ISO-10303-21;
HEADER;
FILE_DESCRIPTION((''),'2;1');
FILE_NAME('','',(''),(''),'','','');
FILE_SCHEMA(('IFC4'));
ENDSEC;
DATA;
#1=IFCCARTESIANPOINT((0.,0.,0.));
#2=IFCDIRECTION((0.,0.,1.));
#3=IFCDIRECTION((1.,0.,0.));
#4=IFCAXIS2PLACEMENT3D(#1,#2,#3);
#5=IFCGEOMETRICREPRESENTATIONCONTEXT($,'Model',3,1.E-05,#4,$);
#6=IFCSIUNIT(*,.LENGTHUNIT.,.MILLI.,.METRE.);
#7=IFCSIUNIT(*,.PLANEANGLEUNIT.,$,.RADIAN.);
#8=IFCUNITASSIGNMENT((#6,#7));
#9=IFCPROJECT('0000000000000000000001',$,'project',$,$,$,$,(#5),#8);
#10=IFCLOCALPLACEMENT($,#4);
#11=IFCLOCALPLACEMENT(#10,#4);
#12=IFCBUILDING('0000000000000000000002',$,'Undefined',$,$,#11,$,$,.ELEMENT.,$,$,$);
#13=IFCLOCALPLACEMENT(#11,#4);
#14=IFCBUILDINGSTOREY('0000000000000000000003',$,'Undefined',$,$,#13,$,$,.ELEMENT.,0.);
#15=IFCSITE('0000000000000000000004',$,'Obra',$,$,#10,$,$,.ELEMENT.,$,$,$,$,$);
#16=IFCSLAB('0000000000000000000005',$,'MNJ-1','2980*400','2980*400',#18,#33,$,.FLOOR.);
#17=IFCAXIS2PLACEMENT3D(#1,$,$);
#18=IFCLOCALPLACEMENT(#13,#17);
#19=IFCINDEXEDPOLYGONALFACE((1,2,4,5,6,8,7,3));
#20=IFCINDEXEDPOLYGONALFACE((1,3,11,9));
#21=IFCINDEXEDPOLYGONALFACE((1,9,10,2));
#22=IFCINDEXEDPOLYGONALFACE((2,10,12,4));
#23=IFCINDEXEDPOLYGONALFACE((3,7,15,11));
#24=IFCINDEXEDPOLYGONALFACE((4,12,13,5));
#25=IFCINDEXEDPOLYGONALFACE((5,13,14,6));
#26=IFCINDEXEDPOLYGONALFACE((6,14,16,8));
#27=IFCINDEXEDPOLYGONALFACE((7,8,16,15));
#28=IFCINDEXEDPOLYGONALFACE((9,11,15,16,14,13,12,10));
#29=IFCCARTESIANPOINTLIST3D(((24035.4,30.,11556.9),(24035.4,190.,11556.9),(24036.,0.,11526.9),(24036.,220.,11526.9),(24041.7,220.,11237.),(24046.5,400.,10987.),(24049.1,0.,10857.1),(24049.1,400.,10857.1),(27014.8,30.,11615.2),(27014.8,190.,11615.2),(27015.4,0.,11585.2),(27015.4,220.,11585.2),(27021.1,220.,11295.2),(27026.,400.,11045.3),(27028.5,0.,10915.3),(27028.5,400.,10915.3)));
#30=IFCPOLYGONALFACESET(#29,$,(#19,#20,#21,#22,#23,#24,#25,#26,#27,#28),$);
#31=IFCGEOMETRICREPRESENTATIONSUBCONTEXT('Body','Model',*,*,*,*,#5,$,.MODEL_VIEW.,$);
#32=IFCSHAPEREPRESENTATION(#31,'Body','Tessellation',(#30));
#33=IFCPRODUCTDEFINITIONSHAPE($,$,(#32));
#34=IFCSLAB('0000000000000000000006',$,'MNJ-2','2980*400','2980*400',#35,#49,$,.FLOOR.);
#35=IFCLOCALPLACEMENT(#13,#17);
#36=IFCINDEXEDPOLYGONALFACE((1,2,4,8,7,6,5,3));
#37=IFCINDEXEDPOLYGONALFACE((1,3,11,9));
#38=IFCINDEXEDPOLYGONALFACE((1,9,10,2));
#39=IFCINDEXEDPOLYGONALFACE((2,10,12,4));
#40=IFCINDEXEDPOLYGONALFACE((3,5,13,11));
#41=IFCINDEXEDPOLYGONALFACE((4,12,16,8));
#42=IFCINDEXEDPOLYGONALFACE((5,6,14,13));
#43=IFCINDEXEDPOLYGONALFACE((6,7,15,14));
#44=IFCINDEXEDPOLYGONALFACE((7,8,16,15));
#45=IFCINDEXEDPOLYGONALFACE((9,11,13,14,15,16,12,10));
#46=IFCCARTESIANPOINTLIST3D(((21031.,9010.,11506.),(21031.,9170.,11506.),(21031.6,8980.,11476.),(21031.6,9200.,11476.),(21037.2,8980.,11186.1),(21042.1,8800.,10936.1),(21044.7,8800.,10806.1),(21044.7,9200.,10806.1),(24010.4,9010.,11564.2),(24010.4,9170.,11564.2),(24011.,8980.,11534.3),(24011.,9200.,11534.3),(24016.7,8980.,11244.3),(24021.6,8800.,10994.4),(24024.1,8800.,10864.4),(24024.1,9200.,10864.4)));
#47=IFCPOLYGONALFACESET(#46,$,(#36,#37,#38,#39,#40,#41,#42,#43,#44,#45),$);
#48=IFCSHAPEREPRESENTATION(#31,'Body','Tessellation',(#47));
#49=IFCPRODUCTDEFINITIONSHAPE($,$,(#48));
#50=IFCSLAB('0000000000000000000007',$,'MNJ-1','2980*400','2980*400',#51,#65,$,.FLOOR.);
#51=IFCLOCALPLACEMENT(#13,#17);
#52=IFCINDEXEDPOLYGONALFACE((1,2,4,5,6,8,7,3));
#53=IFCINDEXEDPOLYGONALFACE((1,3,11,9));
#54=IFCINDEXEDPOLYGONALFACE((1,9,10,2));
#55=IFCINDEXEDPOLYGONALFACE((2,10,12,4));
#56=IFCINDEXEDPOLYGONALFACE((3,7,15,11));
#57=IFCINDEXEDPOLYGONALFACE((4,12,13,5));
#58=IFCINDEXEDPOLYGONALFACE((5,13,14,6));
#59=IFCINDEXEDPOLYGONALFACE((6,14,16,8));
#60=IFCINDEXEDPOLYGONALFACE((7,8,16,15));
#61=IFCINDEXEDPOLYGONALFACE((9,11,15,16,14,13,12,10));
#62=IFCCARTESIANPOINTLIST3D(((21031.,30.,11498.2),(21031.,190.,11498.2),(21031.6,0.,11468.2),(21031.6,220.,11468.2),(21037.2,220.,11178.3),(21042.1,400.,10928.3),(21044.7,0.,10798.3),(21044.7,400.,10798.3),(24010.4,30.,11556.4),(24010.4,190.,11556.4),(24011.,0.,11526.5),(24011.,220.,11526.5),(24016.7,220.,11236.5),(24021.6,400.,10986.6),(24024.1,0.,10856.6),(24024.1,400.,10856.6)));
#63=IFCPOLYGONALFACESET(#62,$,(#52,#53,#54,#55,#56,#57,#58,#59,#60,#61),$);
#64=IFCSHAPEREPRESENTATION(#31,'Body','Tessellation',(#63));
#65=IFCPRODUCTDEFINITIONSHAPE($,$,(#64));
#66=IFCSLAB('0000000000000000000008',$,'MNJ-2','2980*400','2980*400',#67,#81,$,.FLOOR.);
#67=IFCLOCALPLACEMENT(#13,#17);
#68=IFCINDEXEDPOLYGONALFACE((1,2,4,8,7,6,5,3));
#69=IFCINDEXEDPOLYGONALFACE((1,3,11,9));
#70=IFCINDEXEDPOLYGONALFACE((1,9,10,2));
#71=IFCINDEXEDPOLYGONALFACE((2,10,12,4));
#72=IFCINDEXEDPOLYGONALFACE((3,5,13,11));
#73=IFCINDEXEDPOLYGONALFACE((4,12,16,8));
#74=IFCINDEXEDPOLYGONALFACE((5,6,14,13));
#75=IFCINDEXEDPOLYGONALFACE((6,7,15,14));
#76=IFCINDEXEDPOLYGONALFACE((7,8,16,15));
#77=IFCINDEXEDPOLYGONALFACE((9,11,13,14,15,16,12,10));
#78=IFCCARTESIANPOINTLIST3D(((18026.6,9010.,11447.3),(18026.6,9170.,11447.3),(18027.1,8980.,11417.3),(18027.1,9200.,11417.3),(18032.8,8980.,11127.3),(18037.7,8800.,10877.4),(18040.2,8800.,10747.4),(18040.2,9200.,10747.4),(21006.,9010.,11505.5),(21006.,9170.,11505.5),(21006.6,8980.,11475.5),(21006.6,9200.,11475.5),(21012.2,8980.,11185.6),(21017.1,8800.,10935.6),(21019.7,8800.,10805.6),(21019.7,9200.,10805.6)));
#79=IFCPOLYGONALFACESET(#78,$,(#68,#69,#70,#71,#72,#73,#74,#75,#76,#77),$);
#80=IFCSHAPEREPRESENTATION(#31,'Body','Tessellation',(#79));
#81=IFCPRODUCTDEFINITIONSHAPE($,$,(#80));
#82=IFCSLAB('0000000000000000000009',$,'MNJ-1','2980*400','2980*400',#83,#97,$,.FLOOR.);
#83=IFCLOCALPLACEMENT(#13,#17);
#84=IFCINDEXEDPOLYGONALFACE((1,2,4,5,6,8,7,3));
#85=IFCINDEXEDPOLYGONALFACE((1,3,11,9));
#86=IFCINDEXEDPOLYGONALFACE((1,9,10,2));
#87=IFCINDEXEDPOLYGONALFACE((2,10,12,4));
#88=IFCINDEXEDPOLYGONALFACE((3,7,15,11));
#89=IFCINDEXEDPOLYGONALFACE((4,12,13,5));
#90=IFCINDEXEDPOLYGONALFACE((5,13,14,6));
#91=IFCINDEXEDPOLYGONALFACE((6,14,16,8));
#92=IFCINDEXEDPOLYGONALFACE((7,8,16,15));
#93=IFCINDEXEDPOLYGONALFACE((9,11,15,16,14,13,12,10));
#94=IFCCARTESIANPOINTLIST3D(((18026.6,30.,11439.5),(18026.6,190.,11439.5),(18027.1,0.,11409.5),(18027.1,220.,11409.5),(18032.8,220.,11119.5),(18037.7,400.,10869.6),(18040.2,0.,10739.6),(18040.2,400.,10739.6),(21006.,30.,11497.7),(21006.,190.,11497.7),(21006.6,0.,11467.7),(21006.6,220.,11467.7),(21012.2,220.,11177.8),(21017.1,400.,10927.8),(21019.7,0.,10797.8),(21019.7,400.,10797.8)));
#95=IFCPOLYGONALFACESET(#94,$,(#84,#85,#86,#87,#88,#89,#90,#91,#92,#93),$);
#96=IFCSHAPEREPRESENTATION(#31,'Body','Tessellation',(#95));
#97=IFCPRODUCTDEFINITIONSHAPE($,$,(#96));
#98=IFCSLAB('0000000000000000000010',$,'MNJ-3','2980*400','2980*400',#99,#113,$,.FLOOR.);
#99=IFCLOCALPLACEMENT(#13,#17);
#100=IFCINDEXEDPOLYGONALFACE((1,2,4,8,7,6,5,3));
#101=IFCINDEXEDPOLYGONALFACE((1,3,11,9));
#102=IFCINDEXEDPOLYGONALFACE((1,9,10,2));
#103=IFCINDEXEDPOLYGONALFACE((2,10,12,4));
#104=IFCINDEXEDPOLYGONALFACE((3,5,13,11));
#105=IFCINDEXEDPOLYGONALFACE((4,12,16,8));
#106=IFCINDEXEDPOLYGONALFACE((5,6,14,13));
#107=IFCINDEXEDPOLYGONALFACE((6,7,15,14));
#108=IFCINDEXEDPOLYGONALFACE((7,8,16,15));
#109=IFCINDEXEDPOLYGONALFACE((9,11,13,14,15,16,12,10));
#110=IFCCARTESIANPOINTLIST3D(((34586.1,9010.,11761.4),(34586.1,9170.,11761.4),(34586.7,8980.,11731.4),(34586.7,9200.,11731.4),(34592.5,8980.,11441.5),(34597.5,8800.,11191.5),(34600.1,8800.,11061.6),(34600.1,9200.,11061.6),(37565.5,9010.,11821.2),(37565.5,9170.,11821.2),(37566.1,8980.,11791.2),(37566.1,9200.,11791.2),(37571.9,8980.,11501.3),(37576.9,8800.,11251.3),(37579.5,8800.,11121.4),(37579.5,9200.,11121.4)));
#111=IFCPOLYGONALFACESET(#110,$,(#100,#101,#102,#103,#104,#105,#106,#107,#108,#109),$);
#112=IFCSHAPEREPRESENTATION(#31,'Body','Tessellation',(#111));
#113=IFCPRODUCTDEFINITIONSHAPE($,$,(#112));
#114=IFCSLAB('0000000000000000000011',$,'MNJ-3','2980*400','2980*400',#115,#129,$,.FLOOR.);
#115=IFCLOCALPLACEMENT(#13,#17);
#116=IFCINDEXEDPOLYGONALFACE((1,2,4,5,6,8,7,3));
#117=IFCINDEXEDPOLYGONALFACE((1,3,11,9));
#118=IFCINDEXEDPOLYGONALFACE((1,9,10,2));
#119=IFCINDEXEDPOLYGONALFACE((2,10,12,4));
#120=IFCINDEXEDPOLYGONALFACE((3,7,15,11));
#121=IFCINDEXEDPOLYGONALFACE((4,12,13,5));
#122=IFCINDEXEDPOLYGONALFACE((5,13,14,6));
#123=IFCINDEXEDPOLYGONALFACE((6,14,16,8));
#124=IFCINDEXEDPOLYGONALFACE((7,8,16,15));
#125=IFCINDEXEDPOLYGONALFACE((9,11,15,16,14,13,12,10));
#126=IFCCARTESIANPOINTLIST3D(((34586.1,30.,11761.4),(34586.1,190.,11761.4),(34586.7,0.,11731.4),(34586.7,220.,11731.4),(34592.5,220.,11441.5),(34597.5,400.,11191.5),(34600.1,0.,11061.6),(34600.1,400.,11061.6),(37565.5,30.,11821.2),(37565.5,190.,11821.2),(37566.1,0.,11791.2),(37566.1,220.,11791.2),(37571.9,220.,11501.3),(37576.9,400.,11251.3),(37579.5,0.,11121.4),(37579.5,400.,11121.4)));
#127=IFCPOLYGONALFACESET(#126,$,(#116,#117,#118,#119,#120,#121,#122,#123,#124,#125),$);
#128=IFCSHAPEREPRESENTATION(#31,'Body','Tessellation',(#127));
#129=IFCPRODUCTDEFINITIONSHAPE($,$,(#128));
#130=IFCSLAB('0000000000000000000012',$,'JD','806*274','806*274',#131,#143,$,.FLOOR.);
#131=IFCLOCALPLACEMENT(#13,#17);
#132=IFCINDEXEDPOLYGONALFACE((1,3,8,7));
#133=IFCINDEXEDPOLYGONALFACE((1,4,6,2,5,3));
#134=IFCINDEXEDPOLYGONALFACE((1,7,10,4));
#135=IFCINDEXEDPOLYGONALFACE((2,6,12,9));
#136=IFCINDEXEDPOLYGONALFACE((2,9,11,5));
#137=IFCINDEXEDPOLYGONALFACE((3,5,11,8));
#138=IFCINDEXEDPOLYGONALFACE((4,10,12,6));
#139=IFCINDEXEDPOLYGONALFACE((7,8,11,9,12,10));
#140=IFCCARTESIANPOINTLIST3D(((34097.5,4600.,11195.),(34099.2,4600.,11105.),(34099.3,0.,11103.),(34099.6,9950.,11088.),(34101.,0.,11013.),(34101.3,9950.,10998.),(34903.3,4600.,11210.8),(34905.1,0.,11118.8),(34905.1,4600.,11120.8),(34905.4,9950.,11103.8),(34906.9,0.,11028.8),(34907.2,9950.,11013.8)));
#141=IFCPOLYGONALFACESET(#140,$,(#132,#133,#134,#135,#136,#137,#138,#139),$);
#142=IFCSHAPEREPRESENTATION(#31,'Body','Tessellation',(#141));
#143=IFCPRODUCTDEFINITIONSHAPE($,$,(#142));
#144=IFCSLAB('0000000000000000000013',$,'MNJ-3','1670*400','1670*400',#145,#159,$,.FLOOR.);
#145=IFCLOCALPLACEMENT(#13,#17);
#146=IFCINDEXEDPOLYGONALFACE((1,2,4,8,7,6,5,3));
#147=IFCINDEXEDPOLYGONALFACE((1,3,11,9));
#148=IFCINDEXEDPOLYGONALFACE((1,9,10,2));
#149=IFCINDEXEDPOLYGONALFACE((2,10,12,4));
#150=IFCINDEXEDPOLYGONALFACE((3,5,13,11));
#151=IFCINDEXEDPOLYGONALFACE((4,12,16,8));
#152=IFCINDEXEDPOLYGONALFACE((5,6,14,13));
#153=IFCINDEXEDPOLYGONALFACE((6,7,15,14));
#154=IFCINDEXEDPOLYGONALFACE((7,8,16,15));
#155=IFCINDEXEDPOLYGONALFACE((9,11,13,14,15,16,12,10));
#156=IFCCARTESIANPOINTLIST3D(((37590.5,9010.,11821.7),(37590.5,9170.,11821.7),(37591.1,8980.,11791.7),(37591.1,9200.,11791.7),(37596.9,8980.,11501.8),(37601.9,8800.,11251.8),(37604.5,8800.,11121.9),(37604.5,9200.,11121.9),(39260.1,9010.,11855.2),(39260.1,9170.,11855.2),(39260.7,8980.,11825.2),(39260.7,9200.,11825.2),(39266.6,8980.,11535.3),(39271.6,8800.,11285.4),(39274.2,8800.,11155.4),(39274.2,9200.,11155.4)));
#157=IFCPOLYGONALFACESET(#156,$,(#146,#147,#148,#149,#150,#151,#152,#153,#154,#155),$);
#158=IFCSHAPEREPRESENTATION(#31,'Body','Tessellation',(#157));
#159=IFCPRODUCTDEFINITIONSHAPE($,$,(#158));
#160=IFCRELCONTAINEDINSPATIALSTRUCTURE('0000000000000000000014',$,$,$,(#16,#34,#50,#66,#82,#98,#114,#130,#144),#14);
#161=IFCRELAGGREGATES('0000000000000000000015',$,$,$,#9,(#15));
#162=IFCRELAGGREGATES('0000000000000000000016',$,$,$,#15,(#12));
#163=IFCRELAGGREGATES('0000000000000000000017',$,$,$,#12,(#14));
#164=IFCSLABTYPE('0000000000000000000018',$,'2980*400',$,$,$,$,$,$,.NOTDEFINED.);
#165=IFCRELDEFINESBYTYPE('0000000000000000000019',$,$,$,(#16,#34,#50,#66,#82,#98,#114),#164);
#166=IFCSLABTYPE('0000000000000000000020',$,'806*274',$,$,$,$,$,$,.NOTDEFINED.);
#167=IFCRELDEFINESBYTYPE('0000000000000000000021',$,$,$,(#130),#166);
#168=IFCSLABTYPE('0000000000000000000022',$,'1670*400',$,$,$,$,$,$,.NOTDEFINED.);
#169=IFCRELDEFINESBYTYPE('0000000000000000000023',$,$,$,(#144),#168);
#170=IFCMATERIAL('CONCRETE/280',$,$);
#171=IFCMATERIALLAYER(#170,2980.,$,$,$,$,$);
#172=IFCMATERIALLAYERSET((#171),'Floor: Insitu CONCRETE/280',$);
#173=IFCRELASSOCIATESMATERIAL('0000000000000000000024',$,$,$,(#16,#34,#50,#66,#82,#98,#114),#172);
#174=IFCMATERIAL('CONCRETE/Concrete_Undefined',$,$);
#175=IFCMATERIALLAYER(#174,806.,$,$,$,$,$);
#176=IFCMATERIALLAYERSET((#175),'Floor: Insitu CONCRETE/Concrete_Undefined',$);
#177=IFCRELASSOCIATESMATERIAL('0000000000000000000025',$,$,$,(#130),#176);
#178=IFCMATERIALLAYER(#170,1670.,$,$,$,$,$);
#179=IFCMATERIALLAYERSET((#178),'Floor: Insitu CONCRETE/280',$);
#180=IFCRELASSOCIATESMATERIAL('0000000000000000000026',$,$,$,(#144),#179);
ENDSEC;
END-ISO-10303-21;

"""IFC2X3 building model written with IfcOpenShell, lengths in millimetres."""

from ifc_helpers import new_model, si_unit, frame, origin_with_axes, place, context, subcontext, project, spatial, polyline, outline, extrude, material, layer, layer_set, layer_usage, type_object, element, save


model = new_model("IFC2X3")

# Units and contexts
model_context = context("Model", 3, precision=1e-05, world=origin_with_axes())
body_context = subcontext(model_context, "Body", "Model", "MODEL_VIEW")
ifc_project = project(units=[si_unit("LENGTHUNIT", "METRE", prefix="MILLI"), si_unit("PLANEANGLEUNIT", "RADIAN")], contexts=[model_context])

# Site, building, storey
site_placement = place(None, origin_with_axes())
site = spatial("IfcSite", under=ifc_project, at=site_placement, Name="Obra", CompositionType="ELEMENT")
building_placement = place(site_placement, origin_with_axes())
building = spatial("IfcBuilding", under=site, at=building_placement, Name="Undefined", CompositionType="ELEMENT")
storey_placement = place(building_placement, origin_with_axes())
storey = spatial("IfcBuildingStorey", under=building, at=storey_placement, Name="Undefined", CompositionType="ELEMENT", Elevation=0.0)

# Shared definitions
ifc_material_1 = material(Name="CONCRETE/280")

# Slabs
ifc_layer_1 = layer(ifc_material_1, 2980.0)
ifc_layer_set_1 = layer_set([ifc_layer_1], Name="Floor: Insitu CONCRETE/280")
slab_type_1 = type_object("IfcSlabType", Name="2980*400", PredefinedType="NOTDEFINED")
ifc_layer_usage_1 = layer_usage(ifc_layer_set_1, "AXIS3", "POSITIVE", -1490.0)
slab_1_placement = place(storey_placement, frame((25525.7, 0.0, 11556.1), z_axis=(0.999809, 0.0, 0.019547), x_axis=(0.019547, 0.0, -0.999809)))
element("IfcSlab", 1, at=slab_1_placement, inside=storey, type_object=slab_type_1, material=ifc_layer_usage_1, Name="MNJ-1", Description="2980*400", ObjectType="2980*400", PredefinedType="FLOOR", context=body_context, shape_type="SweptSolid", body=[
    extrude(outline(polyline([(0.0, 0.0), (670.0, 0.0), (670.0, 400.0), (540.0, 400.0), (290.0, 220.0), (0.0, 220.0), (-30.0, 190.0), (-30.0, 30.0), (0.0, 0.0)])), frame((0.0, 0.0, -1490.0), z_axis=(0.0, 0.0, 1.0), x_axis=(1.0, 0.0, 0.0)), (0.0, 0.0, 1.0), 2980.0),
])
ifc_layer_usage_2 = layer_usage(ifc_layer_set_1, "AXIS3", "POSITIVE", -1490.0)
slab_2_placement = place(storey_placement, frame((22521.3, 9200.0, 11505.1), z_axis=(-0.999809, 0.0, -0.019547), x_axis=(0.019547, 0.0, -0.999809)))
element("IfcSlab", 2, at=slab_2_placement, inside=storey, type_object=slab_type_1, material=ifc_layer_usage_2, Name="MNJ-2", Description="2980*400", ObjectType="2980*400", PredefinedType="FLOOR", context=body_context, shape_type="SweptSolid", body=[
    extrude(outline(polyline([(0.0, 0.0), (670.0, 0.0), (670.0, 400.0), (540.0, 400.0), (290.0, 220.0), (0.0, 220.0), (-30.0, 190.0), (-30.0, 30.0), (0.0, 0.0)])), frame((0.0, 0.0, -1490.0), z_axis=(0.0, 0.0, 1.0), x_axis=(1.0, 0.0, 0.0)), (0.0, 0.0, 1.0), 2980.0),
])
ifc_layer_usage_3 = layer_usage(ifc_layer_set_1, "AXIS3", "POSITIVE", -1490.0)
slab_3_placement = place(storey_placement, frame((22521.3, 0.0, 11497.3), z_axis=(0.999809, 0.0, 0.019547), x_axis=(0.019547, 0.0, -0.999809)))
element("IfcSlab", 3, at=slab_3_placement, inside=storey, type_object=slab_type_1, material=ifc_layer_usage_3, Name="MNJ-1", Description="2980*400", ObjectType="2980*400", PredefinedType="FLOOR", context=body_context, shape_type="SweptSolid", body=[
    extrude(outline(polyline([(0.0, 0.0), (670.0, 0.0), (670.0, 400.0), (540.0, 400.0), (290.0, 220.0), (0.0, 220.0), (-30.0, 190.0), (-30.0, 30.0), (0.0, 0.0)])), frame((0.0, 0.0, -1490.0), z_axis=(0.0, 0.0, 1.0), x_axis=(1.0, 0.0, 0.0)), (0.0, 0.0, 1.0), 2980.0),
])
ifc_layer_usage_4 = layer_usage(ifc_layer_set_1, "AXIS3", "POSITIVE", -1490.0)
slab_4_placement = place(storey_placement, frame((19516.9, 9200.0, 11446.4), z_axis=(-0.999809, 0.0, -0.019547), x_axis=(0.019547, 0.0, -0.999809)))
element("IfcSlab", 4, at=slab_4_placement, inside=storey, type_object=slab_type_1, material=ifc_layer_usage_4, Name="MNJ-2", Description="2980*400", ObjectType="2980*400", PredefinedType="FLOOR", context=body_context, shape_type="SweptSolid", body=[
    extrude(outline(polyline([(0.0, 0.0), (670.0, 0.0), (670.0, 400.0), (540.0, 400.0), (290.0, 220.0), (0.0, 220.0), (-30.0, 190.0), (-30.0, 30.0), (0.0, 0.0)])), frame((0.0, 0.0, -1490.0), z_axis=(0.0, 0.0, 1.0), x_axis=(1.0, 0.0, 0.0)), (0.0, 0.0, 1.0), 2980.0),
])
ifc_layer_usage_5 = layer_usage(ifc_layer_set_1, "AXIS3", "POSITIVE", -1490.0)
slab_5_placement = place(storey_placement, frame((19516.9, 0.0, 11438.6), z_axis=(0.999809, 0.0, 0.019547), x_axis=(0.019547, 0.0, -0.999809)))
element("IfcSlab", 5, at=slab_5_placement, inside=storey, type_object=slab_type_1, material=ifc_layer_usage_5, Name="MNJ-1", Description="2980*400", ObjectType="2980*400", PredefinedType="FLOOR", context=body_context, shape_type="SweptSolid", body=[
    extrude(outline(polyline([(0.0, 0.0), (670.0, 0.0), (670.0, 400.0), (540.0, 400.0), (290.0, 220.0), (0.0, 220.0), (-30.0, 190.0), (-30.0, 30.0), (0.0, 0.0)])), frame((0.0, 0.0, -1490.0), z_axis=(0.0, 0.0, 1.0), x_axis=(1.0, 0.0, 0.0)), (0.0, 0.0, 1.0), 2980.0),
])
ifc_layer_usage_6 = layer_usage(ifc_layer_set_1, "AXIS3", "POSITIVE", -1490.0)
slab_6_placement = place(storey_placement, frame((36076.4, 9200.0, 11761.3), z_axis=(-0.999799, 0.0, -0.02007), x_axis=(0.02007, 0.0, -0.999799)))
element("IfcSlab", 6, at=slab_6_placement, inside=storey, type_object=slab_type_1, material=ifc_layer_usage_6, Name="MNJ-3", Description="2980*400", ObjectType="2980*400", PredefinedType="FLOOR", context=body_context, shape_type="SweptSolid", body=[
    extrude(outline(polyline([(0.0, 0.0), (670.0, 0.0), (670.0, 400.0), (540.0, 400.0), (290.0, 220.0), (0.0, 220.0), (-30.0, 190.0), (-30.0, 30.0), (0.0, 0.0)])), frame((0.0, 0.0, -1490.0), z_axis=(0.0, 0.0, 1.0), x_axis=(1.0, 0.0, 0.0)), (0.0, 0.0, 1.0), 2980.0),
])
ifc_layer_usage_7 = layer_usage(ifc_layer_set_1, "AXIS3", "POSITIVE", -1490.0)
slab_7_placement = place(storey_placement, frame((36076.4, 0.0, 11761.3), z_axis=(0.999799, 0.0, 0.02007), x_axis=(0.02007, 0.0, -0.999799)))
element("IfcSlab", 7, at=slab_7_placement, inside=storey, type_object=slab_type_1, material=ifc_layer_usage_7, Name="MNJ-3", Description="2980*400", ObjectType="2980*400", PredefinedType="FLOOR", context=body_context, shape_type="SweptSolid", body=[
    extrude(outline(polyline([(0.0, 0.0), (670.0, 0.0), (670.0, 400.0), (540.0, 400.0), (290.0, 220.0), (0.0, 220.0), (-30.0, 190.0), (-30.0, 30.0), (0.0, 0.0)])), frame((0.0, 0.0, -1490.0), z_axis=(0.0, 0.0, 1.0), x_axis=(1.0, 0.0, 0.0)), (0.0, 0.0, 1.0), 2980.0),
])
ifc_material_2 = material(Name="CONCRETE/Concrete_Undefined")
ifc_layer_2 = layer(ifc_material_2, 806.0)
ifc_layer_set_2 = layer_set([ifc_layer_2], Name="Floor: Insitu CONCRETE/Concrete_Undefined")
ifc_layer_usage_8 = layer_usage(ifc_layer_set_2, "AXIS3", "POSITIVE", -403.0)
slab_type_2 = type_object("IfcSlabType", Name="806*274", PredefinedType="NOTDEFINED")
slab_8_placement = place(storey_placement, frame((34500.4, 4600.0, 11202.9), z_axis=(0.999809, 0.0, 0.019547), x_axis=(0.000391, -0.9998, -0.019992)))
element("IfcSlab", 8, at=slab_8_placement, inside=storey, type_object=slab_type_2, material=ifc_layer_usage_8, Name="JD", Description="806*274", ObjectType="806*274", PredefinedType="FLOOR", context=body_context, shape_type="SweptSolid", body=[
    extrude(outline(polyline([(0.0, 0.0), (4600.9, 0.0), (4602.7, 90.0), (1.8, 90.0), (-5345.0, 303.9), (-5346.8, 214.0), (0.0, 0.0)])), frame((0.0, 0.0, -403.0), z_axis=(0.0, 0.0, 1.0), x_axis=(1.0, 0.0, 0.0)), (0.0, 0.0, 1.0), 806.0),
])
ifc_layer_3 = layer(ifc_material_1, 1670.0)
ifc_layer_set_3 = layer_set([ifc_layer_3], Name="Floor: Insitu CONCRETE/280")
ifc_layer_usage_9 = layer_usage(ifc_layer_set_3, "AXIS3", "POSITIVE", -835.0)
slab_type_3 = type_object("IfcSlabType", Name="1670*400", PredefinedType="NOTDEFINED")
slab_9_placement = place(storey_placement, frame((38425.9, 9200.0, 11808.5), z_axis=(-0.999799, 0.0, -0.02007), x_axis=(0.02007, 0.0, -0.999799)))
element("IfcSlab", 9, at=slab_9_placement, inside=storey, type_object=slab_type_3, material=ifc_layer_usage_9, Name="MNJ-3", Description="1670*400", ObjectType="1670*400", PredefinedType="FLOOR", context=body_context, shape_type="SweptSolid", body=[
    extrude(outline(polyline([(0.0, 0.0), (670.0, 0.0), (670.0, 400.0), (540.0, 400.0), (290.0, 220.0), (0.0, 220.0), (-30.0, 190.0), (-30.0, 30.0), (0.0, 0.0)])), frame((0.0, 0.0, -835.0), z_axis=(0.0, 0.0, 1.0), x_axis=(1.0, 0.0, 0.0)), (0.0, 0.0, 1.0), 1670.0),
])

save(model, "model.ifc")
